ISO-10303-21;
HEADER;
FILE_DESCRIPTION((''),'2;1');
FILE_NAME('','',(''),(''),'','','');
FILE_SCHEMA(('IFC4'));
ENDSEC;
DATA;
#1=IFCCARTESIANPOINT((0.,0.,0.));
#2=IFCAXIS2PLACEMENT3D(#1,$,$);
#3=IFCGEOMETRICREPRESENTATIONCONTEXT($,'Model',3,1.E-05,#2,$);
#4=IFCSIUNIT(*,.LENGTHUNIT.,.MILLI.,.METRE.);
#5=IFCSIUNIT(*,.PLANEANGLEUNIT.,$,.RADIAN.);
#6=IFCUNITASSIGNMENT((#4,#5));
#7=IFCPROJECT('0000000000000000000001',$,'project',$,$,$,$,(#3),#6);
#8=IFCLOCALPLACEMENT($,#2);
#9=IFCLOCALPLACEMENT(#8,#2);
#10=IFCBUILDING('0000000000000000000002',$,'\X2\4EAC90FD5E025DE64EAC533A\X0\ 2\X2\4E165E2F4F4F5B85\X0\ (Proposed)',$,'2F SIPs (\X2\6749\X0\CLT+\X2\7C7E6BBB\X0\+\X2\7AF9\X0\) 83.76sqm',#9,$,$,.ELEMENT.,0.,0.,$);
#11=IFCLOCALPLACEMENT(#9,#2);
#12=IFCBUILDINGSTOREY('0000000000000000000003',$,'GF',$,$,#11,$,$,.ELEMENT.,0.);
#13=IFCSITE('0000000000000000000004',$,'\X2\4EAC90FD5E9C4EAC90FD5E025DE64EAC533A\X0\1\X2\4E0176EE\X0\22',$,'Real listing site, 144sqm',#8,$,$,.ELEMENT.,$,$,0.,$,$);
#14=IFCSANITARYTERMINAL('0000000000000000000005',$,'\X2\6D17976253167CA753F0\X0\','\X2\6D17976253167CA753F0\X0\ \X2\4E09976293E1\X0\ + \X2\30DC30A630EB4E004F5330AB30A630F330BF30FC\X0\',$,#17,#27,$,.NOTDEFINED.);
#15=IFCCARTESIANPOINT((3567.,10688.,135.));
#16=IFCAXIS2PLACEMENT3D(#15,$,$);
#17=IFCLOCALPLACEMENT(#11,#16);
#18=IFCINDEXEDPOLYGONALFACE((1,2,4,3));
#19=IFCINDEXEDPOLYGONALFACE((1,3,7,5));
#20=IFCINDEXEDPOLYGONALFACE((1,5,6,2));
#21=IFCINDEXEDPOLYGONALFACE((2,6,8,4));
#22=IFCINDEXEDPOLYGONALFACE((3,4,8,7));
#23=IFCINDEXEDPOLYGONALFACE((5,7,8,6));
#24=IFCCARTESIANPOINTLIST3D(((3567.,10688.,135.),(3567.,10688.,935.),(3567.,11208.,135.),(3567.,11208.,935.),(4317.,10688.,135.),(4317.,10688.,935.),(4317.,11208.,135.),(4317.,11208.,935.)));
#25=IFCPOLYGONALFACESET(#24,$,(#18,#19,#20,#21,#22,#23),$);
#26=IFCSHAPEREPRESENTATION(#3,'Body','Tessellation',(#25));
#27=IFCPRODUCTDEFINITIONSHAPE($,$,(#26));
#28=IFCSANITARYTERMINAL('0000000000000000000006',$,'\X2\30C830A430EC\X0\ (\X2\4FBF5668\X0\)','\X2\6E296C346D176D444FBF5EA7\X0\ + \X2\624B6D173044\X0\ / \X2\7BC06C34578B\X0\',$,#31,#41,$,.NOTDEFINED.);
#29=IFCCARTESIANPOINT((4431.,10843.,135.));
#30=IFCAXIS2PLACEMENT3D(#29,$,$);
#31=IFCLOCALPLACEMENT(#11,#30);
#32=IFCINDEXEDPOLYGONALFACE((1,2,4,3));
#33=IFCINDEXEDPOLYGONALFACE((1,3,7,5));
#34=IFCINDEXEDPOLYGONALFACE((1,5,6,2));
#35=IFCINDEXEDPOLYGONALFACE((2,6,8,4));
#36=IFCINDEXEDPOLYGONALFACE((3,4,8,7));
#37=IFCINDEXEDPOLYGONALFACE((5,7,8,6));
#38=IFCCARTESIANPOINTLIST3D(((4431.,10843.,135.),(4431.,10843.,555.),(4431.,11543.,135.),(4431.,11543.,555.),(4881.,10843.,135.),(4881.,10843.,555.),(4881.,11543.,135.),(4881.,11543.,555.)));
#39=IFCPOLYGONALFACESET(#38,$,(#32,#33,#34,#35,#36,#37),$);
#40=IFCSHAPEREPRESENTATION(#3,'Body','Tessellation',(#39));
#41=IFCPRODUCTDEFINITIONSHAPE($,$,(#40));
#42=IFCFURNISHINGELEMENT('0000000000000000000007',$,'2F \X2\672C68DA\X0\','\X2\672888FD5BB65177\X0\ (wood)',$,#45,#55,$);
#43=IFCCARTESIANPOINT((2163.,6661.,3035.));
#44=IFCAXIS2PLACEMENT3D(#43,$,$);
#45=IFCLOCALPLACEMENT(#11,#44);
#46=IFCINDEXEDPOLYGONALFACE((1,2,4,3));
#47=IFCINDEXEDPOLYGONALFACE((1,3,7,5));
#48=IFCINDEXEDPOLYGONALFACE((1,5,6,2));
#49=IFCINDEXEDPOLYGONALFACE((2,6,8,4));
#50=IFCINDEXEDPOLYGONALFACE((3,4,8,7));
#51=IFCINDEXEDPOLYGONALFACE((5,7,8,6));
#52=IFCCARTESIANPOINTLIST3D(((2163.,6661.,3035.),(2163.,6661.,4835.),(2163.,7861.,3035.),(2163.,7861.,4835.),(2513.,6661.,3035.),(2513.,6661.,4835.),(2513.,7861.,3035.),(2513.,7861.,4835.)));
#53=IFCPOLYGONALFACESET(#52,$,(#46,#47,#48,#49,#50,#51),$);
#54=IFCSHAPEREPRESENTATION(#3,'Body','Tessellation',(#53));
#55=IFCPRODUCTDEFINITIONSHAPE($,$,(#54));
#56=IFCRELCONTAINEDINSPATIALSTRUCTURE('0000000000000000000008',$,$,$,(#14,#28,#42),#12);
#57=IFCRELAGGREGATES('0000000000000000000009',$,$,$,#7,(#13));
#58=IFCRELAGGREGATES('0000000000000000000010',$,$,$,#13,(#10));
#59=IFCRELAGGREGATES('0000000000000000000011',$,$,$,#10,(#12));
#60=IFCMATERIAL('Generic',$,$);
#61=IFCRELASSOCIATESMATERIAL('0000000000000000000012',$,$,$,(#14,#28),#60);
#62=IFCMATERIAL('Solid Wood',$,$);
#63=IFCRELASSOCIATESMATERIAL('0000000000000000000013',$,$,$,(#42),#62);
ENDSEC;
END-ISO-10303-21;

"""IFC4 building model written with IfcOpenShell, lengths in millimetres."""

from ifc_helpers import new_model, si_unit, frame, frame_2d, origin, place, context, project, spatial, rectangle, extrude, material, element, save


model = new_model("IFC4")

# Units and contexts
model_context = context("Model", 3, precision=1e-05, world=origin())
ifc_project = project(units=[si_unit("LENGTHUNIT", "METRE", prefix="MILLI"), si_unit("PLANEANGLEUNIT", "RADIAN")], contexts=[model_context])

# Site, building, storey
site_placement = place(None, origin())
site = spatial("IfcSite", under=ifc_project, at=site_placement, Name="京都府京都市左京区1丁目22", ObjectType="Real listing site, 144sqm", CompositionType="ELEMENT", RefElevation=0.0)
building_placement = place(site_placement, origin())
building = spatial("IfcBuilding", under=site, at=building_placement, Name="京都市左京区 2世帯住宅 (Proposed)", ObjectType="2F SIPs (杉CLT+籾殻+竹) 83.76sqm", CompositionType="ELEMENT", ElevationOfRefHeight=0.0, ElevationOfTerrain=0.0)
storey_placement = place(building_placement, origin())
storey = spatial("IfcBuildingStorey", under=building, at=storey_placement, Name="GF", CompositionType="ELEMENT", Elevation=0.0)

# Shared definitions
ifc_material_1 = material(Name="Solid Wood")

# Shared definitions
ifc_material_2 = material(Name="Generic")

# Sanitary terminals
sanitary_terminal_1_placement = place(storey_placement, frame((3567.0, 10688.0, 135.0)))
element("IfcSanitaryTerminal", 1, at=sanitary_terminal_1_placement, inside=storey, material=ifc_material_2, Name="洗面化粧台", Description="洗面化粧台 三面鏡 + ボウル一体カウンター", PredefinedType="NOTDEFINED", context=model_context, shape_type="SweptSolid", body=[
    extrude(rectangle(XDim=750.0, YDim=520.0, at=frame_2d((375.0, 260.0))), frame((3567.0, 10688.0, 135.0)), (0.0, 0.0, 1.0), 800.0),
])
sanitary_terminal_2_placement = place(storey_placement, frame((4431.0, 10843.0, 135.0)))
element("IfcSanitaryTerminal", 2, at=sanitary_terminal_2_placement, inside=storey, material=ifc_material_2, Name="トイレ (便器)", Description="温水洗浄便座 + 手洗い / 節水型", PredefinedType="NOTDEFINED", context=model_context, shape_type="SweptSolid", body=[
    extrude(rectangle(XDim=450.0, YDim=700.0, at=frame_2d((225.0, 350.0))), frame((4431.0, 10843.0, 135.0)), (0.0, 0.0, 1.0), 420.0),
])

# Furnishing element
furnishing_placement = place(storey_placement, frame((2163.0, 6661.0, 3035.0)))
element("IfcFurnishingElement", 3, at=furnishing_placement, inside=storey, material=ifc_material_1, Name="2F 本棚", Description="木製家具 (wood)", context=model_context, shape_type="SweptSolid", body=[
    extrude(rectangle(XDim=350.0, YDim=1200.0, at=frame_2d((175.0, 600.0))), frame((2163.0, 6661.0, 3035.0)), (0.0, 0.0, 1.0), 1800.0),
])

save(model, "model.ifc")
